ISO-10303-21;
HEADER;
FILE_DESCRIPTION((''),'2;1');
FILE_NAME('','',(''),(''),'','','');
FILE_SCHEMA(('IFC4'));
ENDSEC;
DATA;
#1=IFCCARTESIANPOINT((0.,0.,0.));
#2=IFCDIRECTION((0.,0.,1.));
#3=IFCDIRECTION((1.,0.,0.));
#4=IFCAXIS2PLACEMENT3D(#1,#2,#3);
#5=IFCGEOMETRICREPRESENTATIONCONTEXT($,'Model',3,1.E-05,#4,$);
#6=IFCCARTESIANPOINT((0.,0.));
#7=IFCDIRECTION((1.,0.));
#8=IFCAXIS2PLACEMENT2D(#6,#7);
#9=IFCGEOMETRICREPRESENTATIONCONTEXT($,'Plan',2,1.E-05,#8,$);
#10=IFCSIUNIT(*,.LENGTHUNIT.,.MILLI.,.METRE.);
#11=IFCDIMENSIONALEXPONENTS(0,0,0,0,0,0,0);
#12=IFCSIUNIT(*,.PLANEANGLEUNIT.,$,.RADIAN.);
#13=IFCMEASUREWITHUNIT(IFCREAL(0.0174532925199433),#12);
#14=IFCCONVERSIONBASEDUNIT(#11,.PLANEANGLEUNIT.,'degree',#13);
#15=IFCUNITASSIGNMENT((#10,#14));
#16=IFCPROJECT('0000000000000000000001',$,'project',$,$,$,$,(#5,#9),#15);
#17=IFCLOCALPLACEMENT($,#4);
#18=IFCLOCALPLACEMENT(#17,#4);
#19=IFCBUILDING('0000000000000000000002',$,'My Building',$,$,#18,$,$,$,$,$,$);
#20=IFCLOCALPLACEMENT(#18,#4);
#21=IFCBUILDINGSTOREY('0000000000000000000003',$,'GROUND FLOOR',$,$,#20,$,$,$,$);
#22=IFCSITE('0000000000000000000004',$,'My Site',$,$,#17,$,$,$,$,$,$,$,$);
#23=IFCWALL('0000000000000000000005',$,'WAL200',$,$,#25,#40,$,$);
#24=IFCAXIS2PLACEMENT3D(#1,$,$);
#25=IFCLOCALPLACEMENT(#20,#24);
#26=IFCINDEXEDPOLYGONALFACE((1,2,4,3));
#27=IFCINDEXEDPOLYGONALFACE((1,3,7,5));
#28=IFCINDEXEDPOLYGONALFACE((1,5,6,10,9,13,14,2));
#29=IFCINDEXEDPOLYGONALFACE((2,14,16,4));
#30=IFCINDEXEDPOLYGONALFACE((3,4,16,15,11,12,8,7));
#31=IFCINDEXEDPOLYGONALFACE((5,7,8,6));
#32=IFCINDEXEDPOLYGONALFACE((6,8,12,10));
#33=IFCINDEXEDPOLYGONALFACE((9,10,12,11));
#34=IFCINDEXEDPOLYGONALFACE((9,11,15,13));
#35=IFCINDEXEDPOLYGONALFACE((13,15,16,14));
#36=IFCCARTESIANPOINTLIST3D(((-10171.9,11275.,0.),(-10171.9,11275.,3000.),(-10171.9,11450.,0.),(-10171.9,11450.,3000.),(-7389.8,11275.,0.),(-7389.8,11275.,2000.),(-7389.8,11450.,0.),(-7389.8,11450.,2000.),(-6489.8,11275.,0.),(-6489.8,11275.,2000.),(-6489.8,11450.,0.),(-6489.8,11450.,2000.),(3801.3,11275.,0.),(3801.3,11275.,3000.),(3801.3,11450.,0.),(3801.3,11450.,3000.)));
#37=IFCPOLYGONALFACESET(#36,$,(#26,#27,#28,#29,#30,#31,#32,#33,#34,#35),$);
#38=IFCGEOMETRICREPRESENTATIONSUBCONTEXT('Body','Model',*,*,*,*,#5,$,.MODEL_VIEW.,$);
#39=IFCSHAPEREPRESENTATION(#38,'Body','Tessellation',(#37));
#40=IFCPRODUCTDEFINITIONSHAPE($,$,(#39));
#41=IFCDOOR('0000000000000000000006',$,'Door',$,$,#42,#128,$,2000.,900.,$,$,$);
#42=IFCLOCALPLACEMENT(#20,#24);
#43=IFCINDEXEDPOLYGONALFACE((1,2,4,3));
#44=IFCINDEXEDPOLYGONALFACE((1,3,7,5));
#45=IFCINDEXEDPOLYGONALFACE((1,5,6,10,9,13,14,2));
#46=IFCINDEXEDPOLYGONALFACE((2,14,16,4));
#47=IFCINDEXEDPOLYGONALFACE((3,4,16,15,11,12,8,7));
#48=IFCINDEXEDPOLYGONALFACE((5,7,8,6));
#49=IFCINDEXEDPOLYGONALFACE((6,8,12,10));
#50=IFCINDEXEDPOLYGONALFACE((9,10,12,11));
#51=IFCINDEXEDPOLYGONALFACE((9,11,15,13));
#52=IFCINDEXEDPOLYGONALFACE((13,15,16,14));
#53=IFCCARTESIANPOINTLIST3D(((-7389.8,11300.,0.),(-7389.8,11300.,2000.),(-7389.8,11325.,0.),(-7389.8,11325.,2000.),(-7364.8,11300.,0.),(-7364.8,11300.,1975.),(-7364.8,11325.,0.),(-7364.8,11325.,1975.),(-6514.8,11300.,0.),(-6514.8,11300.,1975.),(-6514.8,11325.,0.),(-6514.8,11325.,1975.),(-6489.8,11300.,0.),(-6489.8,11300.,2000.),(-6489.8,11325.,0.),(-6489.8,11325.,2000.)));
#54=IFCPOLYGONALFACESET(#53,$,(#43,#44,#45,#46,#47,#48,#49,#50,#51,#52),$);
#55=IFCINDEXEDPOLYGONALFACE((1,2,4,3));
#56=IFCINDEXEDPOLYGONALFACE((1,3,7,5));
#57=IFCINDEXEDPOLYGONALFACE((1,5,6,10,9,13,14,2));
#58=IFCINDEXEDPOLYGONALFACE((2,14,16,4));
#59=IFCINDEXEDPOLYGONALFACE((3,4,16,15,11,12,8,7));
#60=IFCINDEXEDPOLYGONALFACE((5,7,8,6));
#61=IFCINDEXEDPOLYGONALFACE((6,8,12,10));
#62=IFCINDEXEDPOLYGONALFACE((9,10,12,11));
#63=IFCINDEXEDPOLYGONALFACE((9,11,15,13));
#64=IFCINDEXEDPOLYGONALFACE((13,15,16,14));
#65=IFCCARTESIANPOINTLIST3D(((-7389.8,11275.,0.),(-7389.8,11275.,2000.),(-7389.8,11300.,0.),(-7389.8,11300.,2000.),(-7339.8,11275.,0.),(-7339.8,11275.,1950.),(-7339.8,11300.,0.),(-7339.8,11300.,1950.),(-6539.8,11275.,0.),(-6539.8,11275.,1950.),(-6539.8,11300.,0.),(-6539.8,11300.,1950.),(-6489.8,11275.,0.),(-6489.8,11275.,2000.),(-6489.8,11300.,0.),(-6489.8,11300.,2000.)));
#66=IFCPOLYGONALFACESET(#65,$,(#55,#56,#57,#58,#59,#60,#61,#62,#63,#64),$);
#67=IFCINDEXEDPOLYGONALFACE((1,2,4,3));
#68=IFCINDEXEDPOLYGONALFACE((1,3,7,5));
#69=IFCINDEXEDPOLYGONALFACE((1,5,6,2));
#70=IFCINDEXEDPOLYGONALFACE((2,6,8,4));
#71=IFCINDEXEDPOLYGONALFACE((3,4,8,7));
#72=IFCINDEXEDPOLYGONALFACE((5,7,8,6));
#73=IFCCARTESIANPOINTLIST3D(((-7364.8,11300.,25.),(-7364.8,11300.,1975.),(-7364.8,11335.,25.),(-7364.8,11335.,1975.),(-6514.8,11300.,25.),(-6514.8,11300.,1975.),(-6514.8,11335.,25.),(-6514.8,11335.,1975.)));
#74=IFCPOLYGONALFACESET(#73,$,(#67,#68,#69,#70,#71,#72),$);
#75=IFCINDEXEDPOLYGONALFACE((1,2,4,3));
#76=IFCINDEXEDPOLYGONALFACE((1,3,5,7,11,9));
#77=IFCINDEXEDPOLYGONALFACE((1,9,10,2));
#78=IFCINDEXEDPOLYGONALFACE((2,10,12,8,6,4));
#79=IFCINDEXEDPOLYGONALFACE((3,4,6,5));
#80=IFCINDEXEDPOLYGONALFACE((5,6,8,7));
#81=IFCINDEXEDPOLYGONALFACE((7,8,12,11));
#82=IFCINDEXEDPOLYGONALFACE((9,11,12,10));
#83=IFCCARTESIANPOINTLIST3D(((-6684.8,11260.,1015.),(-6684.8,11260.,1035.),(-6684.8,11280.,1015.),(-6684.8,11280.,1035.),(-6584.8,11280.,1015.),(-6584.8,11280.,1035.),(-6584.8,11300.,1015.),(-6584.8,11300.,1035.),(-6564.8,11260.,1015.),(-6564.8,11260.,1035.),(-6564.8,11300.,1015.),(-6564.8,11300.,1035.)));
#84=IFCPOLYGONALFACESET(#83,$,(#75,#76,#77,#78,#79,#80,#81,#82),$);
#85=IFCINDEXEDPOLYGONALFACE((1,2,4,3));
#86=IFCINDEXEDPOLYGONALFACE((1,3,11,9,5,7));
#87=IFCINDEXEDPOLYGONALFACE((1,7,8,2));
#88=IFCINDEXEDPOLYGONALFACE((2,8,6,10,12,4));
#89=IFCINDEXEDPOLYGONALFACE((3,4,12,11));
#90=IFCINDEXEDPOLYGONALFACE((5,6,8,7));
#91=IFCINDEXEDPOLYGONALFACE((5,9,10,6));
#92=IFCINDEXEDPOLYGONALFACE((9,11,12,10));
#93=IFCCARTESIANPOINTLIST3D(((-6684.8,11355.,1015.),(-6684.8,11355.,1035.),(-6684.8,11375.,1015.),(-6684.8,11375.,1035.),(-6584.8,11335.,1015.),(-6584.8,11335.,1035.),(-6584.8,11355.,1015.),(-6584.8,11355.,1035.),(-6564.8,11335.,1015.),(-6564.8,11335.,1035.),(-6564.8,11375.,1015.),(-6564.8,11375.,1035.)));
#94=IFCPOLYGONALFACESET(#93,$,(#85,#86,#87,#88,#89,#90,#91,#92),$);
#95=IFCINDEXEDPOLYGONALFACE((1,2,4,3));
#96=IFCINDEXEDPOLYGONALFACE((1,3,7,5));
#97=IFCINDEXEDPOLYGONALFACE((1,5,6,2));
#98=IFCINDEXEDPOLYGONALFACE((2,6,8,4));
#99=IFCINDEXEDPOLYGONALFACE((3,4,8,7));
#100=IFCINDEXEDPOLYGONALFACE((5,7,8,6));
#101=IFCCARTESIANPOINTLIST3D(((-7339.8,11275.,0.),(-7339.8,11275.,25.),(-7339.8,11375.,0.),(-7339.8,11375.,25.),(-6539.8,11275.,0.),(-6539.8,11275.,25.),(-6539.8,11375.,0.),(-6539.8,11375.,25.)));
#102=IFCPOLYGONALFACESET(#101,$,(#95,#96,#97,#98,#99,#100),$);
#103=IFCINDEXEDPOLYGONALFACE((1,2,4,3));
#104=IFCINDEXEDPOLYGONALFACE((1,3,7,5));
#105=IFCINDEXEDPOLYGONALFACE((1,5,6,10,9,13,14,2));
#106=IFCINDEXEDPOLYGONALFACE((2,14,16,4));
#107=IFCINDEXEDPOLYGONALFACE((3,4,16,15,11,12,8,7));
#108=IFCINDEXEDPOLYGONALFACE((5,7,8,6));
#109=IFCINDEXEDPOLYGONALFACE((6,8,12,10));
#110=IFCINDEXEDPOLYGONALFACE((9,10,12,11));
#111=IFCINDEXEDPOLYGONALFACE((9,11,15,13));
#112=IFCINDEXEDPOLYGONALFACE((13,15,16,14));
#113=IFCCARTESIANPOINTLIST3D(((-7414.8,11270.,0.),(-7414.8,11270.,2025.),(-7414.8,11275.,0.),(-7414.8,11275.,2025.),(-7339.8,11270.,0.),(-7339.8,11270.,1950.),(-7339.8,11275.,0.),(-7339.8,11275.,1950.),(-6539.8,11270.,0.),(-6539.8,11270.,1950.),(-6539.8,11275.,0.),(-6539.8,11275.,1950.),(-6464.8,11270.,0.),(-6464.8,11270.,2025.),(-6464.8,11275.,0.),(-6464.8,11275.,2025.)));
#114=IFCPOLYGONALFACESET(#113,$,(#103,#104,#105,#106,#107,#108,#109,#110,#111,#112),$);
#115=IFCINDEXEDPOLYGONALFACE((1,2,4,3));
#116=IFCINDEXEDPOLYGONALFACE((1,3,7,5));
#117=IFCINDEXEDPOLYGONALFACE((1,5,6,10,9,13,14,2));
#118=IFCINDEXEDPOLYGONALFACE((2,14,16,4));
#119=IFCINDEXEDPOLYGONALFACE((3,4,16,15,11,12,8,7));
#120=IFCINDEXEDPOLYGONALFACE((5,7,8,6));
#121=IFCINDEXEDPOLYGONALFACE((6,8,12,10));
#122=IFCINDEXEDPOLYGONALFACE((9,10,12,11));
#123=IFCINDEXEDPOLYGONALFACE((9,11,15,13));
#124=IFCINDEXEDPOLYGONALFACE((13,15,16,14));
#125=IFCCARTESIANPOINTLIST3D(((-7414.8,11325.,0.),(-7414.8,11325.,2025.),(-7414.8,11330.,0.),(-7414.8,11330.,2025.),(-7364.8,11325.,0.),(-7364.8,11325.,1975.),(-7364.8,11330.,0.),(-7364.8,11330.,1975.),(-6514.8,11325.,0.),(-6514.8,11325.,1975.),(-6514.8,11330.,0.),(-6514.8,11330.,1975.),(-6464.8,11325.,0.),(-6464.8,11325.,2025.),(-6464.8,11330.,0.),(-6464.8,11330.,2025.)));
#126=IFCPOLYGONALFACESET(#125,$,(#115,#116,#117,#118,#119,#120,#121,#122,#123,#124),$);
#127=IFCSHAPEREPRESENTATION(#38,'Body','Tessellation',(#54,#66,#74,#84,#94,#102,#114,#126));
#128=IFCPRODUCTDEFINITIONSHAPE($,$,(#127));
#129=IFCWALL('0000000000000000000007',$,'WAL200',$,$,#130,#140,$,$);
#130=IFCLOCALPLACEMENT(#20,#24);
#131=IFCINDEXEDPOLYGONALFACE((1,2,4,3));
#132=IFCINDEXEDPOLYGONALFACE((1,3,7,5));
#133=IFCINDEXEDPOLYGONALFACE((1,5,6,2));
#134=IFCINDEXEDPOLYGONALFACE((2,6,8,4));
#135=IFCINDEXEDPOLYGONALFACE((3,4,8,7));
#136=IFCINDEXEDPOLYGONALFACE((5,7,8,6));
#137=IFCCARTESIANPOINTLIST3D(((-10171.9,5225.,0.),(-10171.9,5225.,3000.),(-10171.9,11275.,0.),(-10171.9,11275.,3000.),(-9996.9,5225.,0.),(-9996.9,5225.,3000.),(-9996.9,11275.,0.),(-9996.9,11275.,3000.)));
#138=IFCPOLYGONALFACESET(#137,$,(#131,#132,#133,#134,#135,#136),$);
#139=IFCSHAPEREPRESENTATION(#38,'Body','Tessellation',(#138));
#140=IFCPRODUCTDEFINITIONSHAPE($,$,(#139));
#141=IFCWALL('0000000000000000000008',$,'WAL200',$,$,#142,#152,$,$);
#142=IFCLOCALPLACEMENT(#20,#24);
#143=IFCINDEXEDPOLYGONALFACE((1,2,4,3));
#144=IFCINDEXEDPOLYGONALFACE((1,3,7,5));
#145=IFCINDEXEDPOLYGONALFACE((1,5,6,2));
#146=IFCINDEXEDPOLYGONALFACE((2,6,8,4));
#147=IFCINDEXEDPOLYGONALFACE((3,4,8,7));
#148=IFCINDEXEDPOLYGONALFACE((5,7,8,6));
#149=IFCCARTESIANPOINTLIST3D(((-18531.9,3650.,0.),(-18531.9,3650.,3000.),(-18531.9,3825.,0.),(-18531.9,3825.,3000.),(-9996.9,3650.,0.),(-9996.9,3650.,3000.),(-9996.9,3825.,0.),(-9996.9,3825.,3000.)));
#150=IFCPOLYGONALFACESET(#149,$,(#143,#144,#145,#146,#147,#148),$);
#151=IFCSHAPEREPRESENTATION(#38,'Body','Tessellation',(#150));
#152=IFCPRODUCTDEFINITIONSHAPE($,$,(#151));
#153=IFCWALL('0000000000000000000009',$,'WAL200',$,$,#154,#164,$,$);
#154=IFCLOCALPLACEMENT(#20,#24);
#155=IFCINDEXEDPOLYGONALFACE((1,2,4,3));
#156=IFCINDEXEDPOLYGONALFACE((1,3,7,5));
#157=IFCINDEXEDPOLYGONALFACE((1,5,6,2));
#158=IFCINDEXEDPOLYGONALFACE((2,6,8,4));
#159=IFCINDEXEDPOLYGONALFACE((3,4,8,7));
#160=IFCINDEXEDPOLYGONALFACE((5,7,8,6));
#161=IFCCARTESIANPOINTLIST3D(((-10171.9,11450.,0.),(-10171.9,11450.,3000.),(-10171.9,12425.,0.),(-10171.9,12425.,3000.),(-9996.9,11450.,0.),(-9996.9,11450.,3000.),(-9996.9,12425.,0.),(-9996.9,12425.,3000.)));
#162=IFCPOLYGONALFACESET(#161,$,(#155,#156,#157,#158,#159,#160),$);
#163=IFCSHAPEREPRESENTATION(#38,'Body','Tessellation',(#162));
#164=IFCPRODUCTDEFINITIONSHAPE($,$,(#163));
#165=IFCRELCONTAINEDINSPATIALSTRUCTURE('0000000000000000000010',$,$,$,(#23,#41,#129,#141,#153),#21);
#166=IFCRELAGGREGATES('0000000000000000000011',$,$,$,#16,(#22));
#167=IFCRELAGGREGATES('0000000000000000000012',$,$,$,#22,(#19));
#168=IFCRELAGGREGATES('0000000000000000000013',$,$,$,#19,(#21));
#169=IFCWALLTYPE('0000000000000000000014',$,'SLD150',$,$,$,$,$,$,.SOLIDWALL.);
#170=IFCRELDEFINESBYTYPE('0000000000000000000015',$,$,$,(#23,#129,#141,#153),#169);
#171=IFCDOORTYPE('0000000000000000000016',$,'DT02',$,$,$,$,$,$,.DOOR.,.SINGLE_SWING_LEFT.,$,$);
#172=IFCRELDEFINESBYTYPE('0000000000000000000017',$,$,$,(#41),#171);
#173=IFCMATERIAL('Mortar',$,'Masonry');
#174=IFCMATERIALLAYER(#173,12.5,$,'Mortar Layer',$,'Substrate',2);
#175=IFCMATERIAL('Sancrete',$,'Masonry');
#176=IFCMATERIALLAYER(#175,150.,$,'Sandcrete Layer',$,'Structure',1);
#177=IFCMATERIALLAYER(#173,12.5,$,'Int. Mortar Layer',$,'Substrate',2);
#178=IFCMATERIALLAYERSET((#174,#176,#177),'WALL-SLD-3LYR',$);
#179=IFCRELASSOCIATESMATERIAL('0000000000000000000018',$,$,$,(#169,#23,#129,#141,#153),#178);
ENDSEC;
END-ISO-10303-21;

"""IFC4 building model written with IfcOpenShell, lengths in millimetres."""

from ifc_helpers import new_model, entity, si_unit, converted_unit, frame, origin_with_axes, origin_2d_with_axis, place, context, subcontext, project, spatial, line, indexed_curve, outline, extrude, shape, source, transform, mapped, material, layer, layer_set, layer_usage, type_object, type_shapes, element, fill, save


model = new_model("IFC4")

# Units and contexts
model_context = context("Model", 3, precision=1e-05, world=origin_with_axes())
plan_context = context("Plan", 2, precision=1e-05, world=origin_2d_with_axis())
body_context_1 = subcontext(model_context, "Body", "Model", "MODEL_VIEW")
body_context_2 = subcontext(plan_context, "Body", "Plan", "PLAN_VIEW")
ifc_project = project(units=[si_unit("LENGTHUNIT", "METRE", prefix="MILLI"), converted_unit("PLANEANGLEUNIT", "degree", entity("IfcReal", 0.0174532925199433), si_unit("PLANEANGLEUNIT", "RADIAN"), dimensions=[0, 0, 0, 0, 0, 0, 0])], contexts=[model_context, plan_context])

# Site, building, storey
site_placement = place(None, origin_with_axes())
site = spatial("IfcSite", under=ifc_project, at=site_placement, Name="My Site")
building_placement = place(site_placement, origin_with_axes())
building = spatial("IfcBuilding", under=site, at=building_placement, Name="My Building")
storey_placement = place(building_placement, origin_with_axes())
storey = spatial("IfcBuildingStorey", under=building, at=storey_placement, Name="GROUND FLOOR")

# Shared definitions
shared_shape_1 = source(origin_with_axes(), body_context_1, "Body", "SweptSolid", [
    extrude(outline(indexed_curve([(0.0, 0.0), (900.0, 0.0), (900.0, 2000.0), (0.0, 2000.0)], segments=[line(1, 2), line(2, 3), line(3, 4), line(4, 1)])), frame((0.0, -100.0, 0.0), z_axis=(0.0, -1.0, 0.0), x_axis=(1.0, 0.0, 0.0)), (0.0, 0.0, -1.0), 300.0),
])
door_type = type_object("IfcDoorType", Name="DT02", OperationType="SINGLE_SWING_LEFT", PredefinedType="DOOR")
shared_shape_2 = source(origin_with_axes(), body_context_1, "Body", "SweptSolid", [
    extrude(outline(indexed_curve([(0.0, 0.0), (0.0, 2000.0), (900.0, 2000.0), (900.0, 0.0), (875.0, 0.0), (875.0, 1975.0), (25.0, 1975.0), (25.0, 0.0)], segments=[line(1, 2), line(2, 3), line(3, 4), line(4, 5), line(5, 6), line(6, 7), line(7, 8), line(8, 1)])), frame((0.0, 25.0, 0.0), z_axis=(0.0, -1.0, 0.0), x_axis=(1.0, 0.0, 0.0)), (0.0, 0.0, -1.0), 25.0),
    extrude(outline(indexed_curve([(0.0, 0.0), (0.0, 2000.0), (900.0, 2000.0), (900.0, 0.0), (850.0, 0.0), (850.0, 1950.0), (50.0, 1950.0), (50.0, 0.0)], segments=[line(1, 2), line(2, 3), line(3, 4), line(4, 5), line(5, 6), line(6, 7), line(7, 8), line(8, 1)])), frame((0.0, 0.0, 0.0), z_axis=(0.0, -1.0, 0.0), x_axis=(1.0, 0.0, 0.0)), (0.0, 0.0, -1.0), 25.0),
    extrude(outline(indexed_curve([(0.0, 0.0), (850.0, 0.0), (850.0, 35.0), (0.0, 35.0)], segments=[line(1, 2), line(2, 3), line(3, 4), line(4, 1)])), frame((25.0, 25.0, 25.0), z_axis=(0.0, 0.0, 1.0), x_axis=(1.0, 0.0, 0.0)), (0.0, 0.0, 1.0), 1950.0),
    extrude(outline(indexed_curve([(0.0, 0.0), (0.0, -40.0), (-120.0, -40.0), (-120.0, -20.0), (-20.0, -20.0), (-20.0, 0.0)], segments=[line(1, 2), line(2, 3), line(3, 4), line(4, 5), line(5, 6), line(6, 1)])), frame((825.0, 25.0, 1015.0), z_axis=(0.0, 0.0, 1.0), x_axis=(1.0, 0.0, 0.0)), (0.0, 0.0, 1.0), 20.0),
    extrude(outline(indexed_curve([(0.0, 0.0), (0.0, 40.0), (-120.0, 40.0), (-120.0, 20.0), (-20.0, 20.0), (-20.0, 0.0)], segments=[line(1, 2), line(2, 3), line(3, 4), line(4, 5), line(5, 6), line(6, 1)])), frame((825.0, 60.0, 1015.0), z_axis=(0.0, 0.0, 1.0), x_axis=(1.0, 0.0, 0.0)), (0.0, 0.0, 1.0), 20.0),
    extrude(outline(indexed_curve([(0.0, 0.0), (800.0, 0.0), (800.0, 100.0), (0.0, 100.0)], segments=[line(1, 2), line(2, 3), line(3, 4), line(4, 1)])), frame((50.0, 0.0, 0.0), z_axis=(0.0, 0.0, 1.0), x_axis=(1.0, 0.0, 0.0)), (0.0, 0.0, 1.0), 25.0),
    extrude(outline(indexed_curve([(0.0, 0.0), (0.0, 2025.0), (950.0, 2025.0), (950.0, 0.0), (875.0, 0.0), (875.0, 1950.0), (75.0, 1950.0), (75.0, 0.0)], segments=[line(1, 2), line(2, 3), line(3, 4), line(4, 5), line(5, 6), line(6, 7), line(7, 8), line(8, 1)])), frame((-25.0, -5.0, 0.0), z_axis=(0.0, -1.0, 0.0), x_axis=(1.0, 0.0, 0.0)), (0.0, 0.0, -1.0), 5.0),
    extrude(outline(indexed_curve([(0.0, 0.0), (0.0, 2025.0), (950.0, 2025.0), (950.0, 0.0), (900.0, 0.0), (900.0, 1975.0), (50.0, 1975.0), (50.0, 0.0)], segments=[line(1, 2), line(2, 3), line(3, 4), line(4, 5), line(5, 6), line(6, 7), line(7, 8), line(8, 1)])), frame((-25.0, 50.0, 0.0), z_axis=(0.0, -1.0, 0.0), x_axis=(1.0, 0.0, 0.0)), (0.0, 0.0, -1.0), 5.0),
])
shared_shape_3 = source(origin_with_axes(), body_context_2, "Body", "Curve2D", [
    entity("IfcIndexedPolyCurve", entity("IfcCartesianPointList2D", [[0.0, 0.0], [0.0, 50.0], [25.0, 50.0], [25.0, 25.0], [50.0, 25.0], [50.0, 0.0]]), [entity("IfcLineIndex", [1, 2]), entity("IfcLineIndex", [2, 3]), entity("IfcLineIndex", [3, 4]), entity("IfcLineIndex", [4, 5]), entity("IfcLineIndex", [5, 6]), entity("IfcLineIndex", [6, 1])]),
    entity("IfcIndexedPolyCurve", entity("IfcCartesianPointList2D", [[900.0, 0.0], [900.0, 50.0], [875.0, 50.0], [875.0, 25.0], [850.0, 25.0], [850.0, 0.0]]), [entity("IfcLineIndex", [1, 2]), entity("IfcLineIndex", [2, 3]), entity("IfcLineIndex", [3, 4]), entity("IfcLineIndex", [4, 5]), entity("IfcLineIndex", [5, 6]), entity("IfcLineIndex", [6, 1])]),
    entity("IfcTrimmedCurve", entity("IfcEllipse", entity("IfcAxis2Placement2D", entity("IfcCartesianPoint", [60.0, 50.0]), entity("IfcDirection", [1.0, 0.0])), 815.0, 850.0), [entity("IfcCartesianPoint", [875.0, 50.0])], [entity("IfcCartesianPoint", [60.0, 900.0])], True, "CARTESIAN"),
    entity("IfcIndexedPolyCurve", entity("IfcCartesianPointList2D", [[25.0, 50.0], [60.0, 50.0], [60.0, 900.0], [25.0, 900.0]]), [entity("IfcLineIndex", [1, 2]), entity("IfcLineIndex", [2, 3]), entity("IfcLineIndex", [3, 4]), entity("IfcLineIndex", [4, 1])]),
])
type_shapes(door_type, [shared_shape_2, shared_shape_3])

# Wall, opening, door
ifc_material_1 = material(Name="Mortar", Category="Masonry")
ifc_layer_1 = layer(ifc_material_1, 12.5, Name="Mortar Layer", Category="Substrate", Priority=2)
ifc_material_2 = material(Name="Sancrete", Category="Masonry")
ifc_layer_2 = layer(ifc_material_2, 150.0, Name="Sandcrete Layer", Category="Structure", Priority=1)
ifc_layer_3 = layer(ifc_material_1, 12.5, Name="Int. Mortar Layer", Category="Substrate", Priority=2)
ifc_layer_set_1 = layer_set([ifc_layer_1, ifc_layer_2, ifc_layer_3], Name="WALL-SLD-3LYR")
ifc_layer_usage_1 = layer_usage(ifc_layer_set_1, "AXIS2", "POSITIVE", 0.0)
wall_type_1 = type_object("IfcWallType", Name="SLD150", PredefinedType="SOLIDWALL", material=ifc_layer_set_1)
wall_1_placement = place(storey_placement, frame((-10171.9, 11275.0, 0.0), z_axis=(0.0, 0.0, 1.0), x_axis=(1.0, 0.0, 0.0)))
wall_1 = element("IfcWall", 1, at=wall_1_placement, inside=storey, type_object=wall_type_1, material=ifc_layer_usage_1, Name="WAL200", context=body_context_1, shape_type="SweptSolid", body=[
    extrude(outline(indexed_curve([(0.0, 0.0), (0.0, 175.0), (13973.2, 175.0), (13973.2, 0.0), (0.0, 0.0)], self_intersect=False)), origin_with_axes(), (0.0, 0.0, 1.0), 3000.0),
])
opening_1_placement = place(wall_1_placement, frame((2782.1, 0.0, 0.0), z_axis=(0.0, 0.0, 1.0), x_axis=(1.0, 0.0, 0.0)))
opening_1 = element("IfcOpeningElement", 2, at=opening_1_placement, cuts=wall_1, PredefinedType="OPENING", context=body_context_1, shape_type="MappedRepresentation", body=[
    mapped(shared_shape_1, transform((0.0, 0.0, 0.0), x_axis=(1.0, 0.0, 0.0), y_axis=(0.0, 1.0, 0.0), z_axis=(0.0, 0.0, 1.0), scale=1.0)),
])
door_1_placement = place(opening_1_placement, origin_with_axes())
door_1 = element("IfcDoor", 3, at=door_1_placement, inside=storey, type_object=door_type, Name="Door", OverallHeight=2000.0, OverallWidth=900.0, shapes=[
    shape(body_context_1, "Body", "MappedRepresentation", [mapped(shared_shape_2, transform((0.0, 0.0, 0.0), x_axis=(1.0, 0.0, 0.0), y_axis=(0.0, 1.0, 0.0), z_axis=(0.0, 0.0, 1.0), scale=1.0))]),
    shape(body_context_2, "Body", "MappedRepresentation", [mapped(shared_shape_3, transform((0.0, 0.0, 0.0), x_axis=(1.0, 0.0, 0.0), y_axis=(0.0, 1.0, 0.0), z_axis=(0.0, 0.0, 1.0), scale=1.0))]),
])
fill(opening_1, door_1)

# Walls
ifc_layer_usage_2 = layer_usage(ifc_layer_set_1, "AXIS2", "POSITIVE", 0.0)
wall_2_placement = place(storey_placement, frame((-10171.9, 11275.0, 0.0), z_axis=(0.0, 0.0, 1.0), x_axis=(-0.000001, -1.0, 0.0)))
element("IfcWall", 4, at=wall_2_placement, inside=storey, type_object=wall_type_1, material=ifc_layer_usage_2, Name="WAL200", context=body_context_1, shape_type="SweptSolid", body=[
    extrude(outline(indexed_curve([(0.0, 0.0), (0.0, 175.0), (6050.0, 175.0), (6050.0, 0.0), (0.0, 0.0)], self_intersect=False)), origin_with_axes(), (0.0, 0.0, 1.0), 3000.0),
])
ifc_layer_usage_3 = layer_usage(ifc_layer_set_1, "AXIS2", "POSITIVE", 0.0)
wall_3_placement = place(storey_placement, frame((-9996.9, 3825.0, 0.0), z_axis=(0.0, 0.0, 1.0), x_axis=(-1.0, 0.0, 0.0)))
element("IfcWall", 5, at=wall_3_placement, inside=storey, type_object=wall_type_1, material=ifc_layer_usage_3, Name="WAL200", context=body_context_1, shape_type="SweptSolid", body=[
    extrude(outline(indexed_curve([(0.0, 0.0), (0.0, 175.0), (8535.0, 175.0), (8535.0, 0.0), (0.0, 0.0)], self_intersect=False)), origin_with_axes(), (0.0, 0.0, 1.0), 3000.0),
])
ifc_layer_usage_4 = layer_usage(ifc_layer_set_1, "AXIS2", "POSITIVE", 0.0)
wall_4_placement = place(storey_placement, frame((-10171.9, 12425.0, 0.0), z_axis=(0.0, 0.0, 1.0), x_axis=(0.0, -1.0, 0.0)))
element("IfcWall", 6, at=wall_4_placement, inside=storey, type_object=wall_type_1, material=ifc_layer_usage_4, Name="WAL200", context=body_context_1, shape_type="SweptSolid", body=[
    extrude(outline(indexed_curve([(0.0, 0.0), (0.0, 175.0), (975.0, 175.0), (975.0, 0.0), (0.0, 0.0)], self_intersect=False)), origin_with_axes(), (0.0, 0.0, 1.0), 3000.0),
])

save(model, "model.ifc")
